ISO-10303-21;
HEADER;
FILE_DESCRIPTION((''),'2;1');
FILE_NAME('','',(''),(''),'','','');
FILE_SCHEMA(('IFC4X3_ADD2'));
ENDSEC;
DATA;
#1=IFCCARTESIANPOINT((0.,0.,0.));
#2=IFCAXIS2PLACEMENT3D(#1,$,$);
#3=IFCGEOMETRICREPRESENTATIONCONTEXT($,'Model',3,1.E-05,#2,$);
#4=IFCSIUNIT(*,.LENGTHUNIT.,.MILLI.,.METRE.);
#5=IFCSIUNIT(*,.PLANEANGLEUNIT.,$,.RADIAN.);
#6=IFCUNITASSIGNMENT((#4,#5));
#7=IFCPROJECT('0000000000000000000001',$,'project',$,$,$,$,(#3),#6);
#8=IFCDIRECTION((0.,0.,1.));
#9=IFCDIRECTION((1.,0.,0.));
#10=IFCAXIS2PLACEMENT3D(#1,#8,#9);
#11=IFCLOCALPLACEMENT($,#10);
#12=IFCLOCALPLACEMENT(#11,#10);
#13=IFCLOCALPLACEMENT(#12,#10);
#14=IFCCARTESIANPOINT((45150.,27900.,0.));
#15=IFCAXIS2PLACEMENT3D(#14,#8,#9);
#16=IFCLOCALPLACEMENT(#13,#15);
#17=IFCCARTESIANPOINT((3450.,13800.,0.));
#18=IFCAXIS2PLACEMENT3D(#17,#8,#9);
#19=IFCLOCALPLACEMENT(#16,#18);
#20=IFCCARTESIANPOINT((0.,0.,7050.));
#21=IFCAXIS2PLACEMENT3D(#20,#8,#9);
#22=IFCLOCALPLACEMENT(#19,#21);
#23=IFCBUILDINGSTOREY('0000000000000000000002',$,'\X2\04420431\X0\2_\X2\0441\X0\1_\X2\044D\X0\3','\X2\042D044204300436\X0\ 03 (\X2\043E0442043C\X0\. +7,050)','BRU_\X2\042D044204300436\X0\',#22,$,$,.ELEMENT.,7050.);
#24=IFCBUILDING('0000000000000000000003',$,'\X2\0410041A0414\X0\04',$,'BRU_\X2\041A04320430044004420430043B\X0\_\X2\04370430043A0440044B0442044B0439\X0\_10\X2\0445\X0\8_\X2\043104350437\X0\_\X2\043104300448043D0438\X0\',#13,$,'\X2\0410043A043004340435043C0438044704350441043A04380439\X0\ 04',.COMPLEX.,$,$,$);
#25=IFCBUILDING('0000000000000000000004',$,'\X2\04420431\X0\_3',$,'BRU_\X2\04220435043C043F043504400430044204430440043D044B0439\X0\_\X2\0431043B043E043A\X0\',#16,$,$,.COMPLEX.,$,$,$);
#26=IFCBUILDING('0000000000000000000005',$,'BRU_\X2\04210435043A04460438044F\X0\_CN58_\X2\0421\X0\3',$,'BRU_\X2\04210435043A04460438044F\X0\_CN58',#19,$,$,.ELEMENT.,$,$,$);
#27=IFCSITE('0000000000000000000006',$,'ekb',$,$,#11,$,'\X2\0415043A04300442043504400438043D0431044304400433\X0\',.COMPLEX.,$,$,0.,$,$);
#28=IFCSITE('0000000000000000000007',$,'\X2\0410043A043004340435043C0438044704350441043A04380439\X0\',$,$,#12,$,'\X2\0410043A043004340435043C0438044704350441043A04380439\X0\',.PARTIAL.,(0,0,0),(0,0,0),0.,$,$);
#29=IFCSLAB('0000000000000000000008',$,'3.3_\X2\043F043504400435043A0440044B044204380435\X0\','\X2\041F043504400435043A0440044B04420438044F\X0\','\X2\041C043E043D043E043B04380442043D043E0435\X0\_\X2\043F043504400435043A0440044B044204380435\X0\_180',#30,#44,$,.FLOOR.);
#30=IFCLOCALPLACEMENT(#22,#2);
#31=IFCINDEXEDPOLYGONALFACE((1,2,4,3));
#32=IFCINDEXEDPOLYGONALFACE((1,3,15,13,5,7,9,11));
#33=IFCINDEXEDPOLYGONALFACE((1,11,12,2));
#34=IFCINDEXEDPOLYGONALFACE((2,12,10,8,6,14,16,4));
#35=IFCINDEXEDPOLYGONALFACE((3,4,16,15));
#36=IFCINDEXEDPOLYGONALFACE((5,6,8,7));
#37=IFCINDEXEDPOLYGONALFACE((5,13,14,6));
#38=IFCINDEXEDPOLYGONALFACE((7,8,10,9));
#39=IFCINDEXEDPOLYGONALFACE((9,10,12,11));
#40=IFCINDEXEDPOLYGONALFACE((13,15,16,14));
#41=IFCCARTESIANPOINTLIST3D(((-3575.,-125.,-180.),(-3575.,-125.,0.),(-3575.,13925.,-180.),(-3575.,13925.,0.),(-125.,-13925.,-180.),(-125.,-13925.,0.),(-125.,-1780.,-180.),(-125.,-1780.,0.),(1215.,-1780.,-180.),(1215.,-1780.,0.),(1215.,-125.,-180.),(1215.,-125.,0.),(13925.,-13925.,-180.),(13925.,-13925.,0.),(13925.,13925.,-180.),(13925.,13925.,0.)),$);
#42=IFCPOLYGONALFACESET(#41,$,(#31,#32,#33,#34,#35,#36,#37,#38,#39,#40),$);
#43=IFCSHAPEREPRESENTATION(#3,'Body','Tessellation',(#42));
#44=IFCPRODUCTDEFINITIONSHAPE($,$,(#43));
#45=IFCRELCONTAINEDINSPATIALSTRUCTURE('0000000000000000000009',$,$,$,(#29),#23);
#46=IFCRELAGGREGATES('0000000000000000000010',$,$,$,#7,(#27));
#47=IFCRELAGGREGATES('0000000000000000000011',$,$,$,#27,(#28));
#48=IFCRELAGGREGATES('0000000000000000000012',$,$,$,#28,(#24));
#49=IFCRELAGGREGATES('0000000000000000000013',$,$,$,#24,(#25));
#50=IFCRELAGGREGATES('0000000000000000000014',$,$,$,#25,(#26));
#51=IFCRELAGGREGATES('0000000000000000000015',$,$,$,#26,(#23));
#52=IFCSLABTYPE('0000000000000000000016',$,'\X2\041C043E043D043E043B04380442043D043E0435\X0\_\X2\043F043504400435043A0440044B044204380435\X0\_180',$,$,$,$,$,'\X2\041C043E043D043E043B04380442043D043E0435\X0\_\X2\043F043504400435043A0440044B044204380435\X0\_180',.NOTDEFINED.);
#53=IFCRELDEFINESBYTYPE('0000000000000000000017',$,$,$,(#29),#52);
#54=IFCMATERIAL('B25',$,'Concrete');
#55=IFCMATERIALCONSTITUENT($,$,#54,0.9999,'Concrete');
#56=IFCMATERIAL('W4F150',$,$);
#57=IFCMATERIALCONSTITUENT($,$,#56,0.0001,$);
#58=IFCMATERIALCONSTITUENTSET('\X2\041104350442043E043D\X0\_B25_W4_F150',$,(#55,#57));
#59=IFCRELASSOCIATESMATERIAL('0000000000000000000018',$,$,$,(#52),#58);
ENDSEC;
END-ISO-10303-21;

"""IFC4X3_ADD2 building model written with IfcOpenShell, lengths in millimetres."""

from ifc_helpers import new_model, si_unit, frame, origin, origin_with_axes, place, context, project, spatial, polyline, outline, extrude, material, constituent, constituent_set, type_object, element, save


model = new_model("IFC4X3_ADD2")

# Units and contexts
model_context = context("Model", 3, precision=1e-05, world=origin())
ifc_project = project(units=[si_unit("LENGTHUNIT", "METRE", prefix="MILLI"), si_unit("PLANEANGLEUNIT", "RADIAN")], contexts=[model_context])

# Sites, buildings, storey
site_1_placement = place(None, origin_with_axes())
site_1 = spatial("IfcSite", under=ifc_project, at=site_1_placement, Name="ekb", LongName="Екатеринбург", CompositionType="COMPLEX", RefElevation=0.0)
site_2_placement = place(site_1_placement, origin_with_axes())
site_2 = spatial("IfcSite", under=site_1, at=site_2_placement, Name="Академический", LongName="Академический", CompositionType="PARTIAL", RefLatitude=(0, 0, 0), RefLongitude=(0, 0, 0), RefElevation=0.0)
building_1_placement = place(site_2_placement, origin_with_axes())
building_1 = spatial("IfcBuilding", under=site_2, at=building_1_placement, Name="АКД04", ObjectType="BRU_Квартал_закрытый_10х8_без_башни", LongName="Академический 04", CompositionType="COMPLEX")
building_2_placement = place(building_1_placement, frame((45150.0, 27900.0, 0.0), z_axis=(0.0, 0.0, 1.0), x_axis=(1.0, 0.0, 0.0)))
building_2 = spatial("IfcBuilding", under=building_1, at=building_2_placement, Name="тб_3", ObjectType="BRU_Температурный_блок", CompositionType="COMPLEX")
building_3_placement = place(building_2_placement, frame((3450.0, 13800.0, 0.0), z_axis=(0.0, 0.0, 1.0), x_axis=(1.0, 0.0, 0.0)))
building_3 = spatial("IfcBuilding", under=building_2, at=building_3_placement, Name="BRU_Секция_CN58_С3", ObjectType="BRU_Секция_CN58", CompositionType="ELEMENT")
storey_placement = place(building_3_placement, frame((0.0, 0.0, 7050.0), z_axis=(0.0, 0.0, 1.0), x_axis=(1.0, 0.0, 0.0)))
storey = spatial("IfcBuildingStorey", under=building_3, at=storey_placement, Name="тб2_с1_э3", Description="Этаж 03 (отм. +7,050)", ObjectType="BRU_Этаж", CompositionType="ELEMENT", Elevation=7050.0)

# Shared definitions
ifc_material_1 = material(Name="B25", Category="Concrete")
ifc_material_2 = material(Name="W4F150")

# Slab
ifc_constituent_1 = constituent(ifc_material_1, Category="Concrete", fraction=0.9999)
ifc_constituent_2 = constituent(ifc_material_2, fraction=0.0001)
ifc_constituent_set_1 = constituent_set(constituents=[ifc_constituent_1, ifc_constituent_2], Name="Бетон_B25_W4_F150")
slab_type = type_object("IfcSlabType", Name="Монолитное_перекрытие_180", ElementType="Монолитное_перекрытие_180", PredefinedType="NOTDEFINED", material=ifc_constituent_set_1)
slab_placement = place(storey_placement, frame((0.0, 0.0, -180.0), z_axis=(0.0, 0.0, 1.0), x_axis=(1.0, 0.0, 0.0)))
element("IfcSlab", 1, at=slab_placement, inside=storey, type_object=slab_type, Name="3.3_перекрытие", Description="Перекрытия", ObjectType="Монолитное_перекрытие_180", PredefinedType="FLOOR", context=model_context, shape_type="SweptSolid", body=[
    extrude(outline(polyline([(-125.0, -13925.0), (13925.0, -13925.0), (13925.0, 13925.0), (-3575.0, 13925.0), (-3575.0, -125.0), (1215.0, -125.0), (1215.0, -1780.0), (-125.0, -1780.0), (-125.0, -13925.0)])), origin_with_axes(), (0.0, 0.0, 1.0), 180.0),
])

save(model, "model.ifc")
